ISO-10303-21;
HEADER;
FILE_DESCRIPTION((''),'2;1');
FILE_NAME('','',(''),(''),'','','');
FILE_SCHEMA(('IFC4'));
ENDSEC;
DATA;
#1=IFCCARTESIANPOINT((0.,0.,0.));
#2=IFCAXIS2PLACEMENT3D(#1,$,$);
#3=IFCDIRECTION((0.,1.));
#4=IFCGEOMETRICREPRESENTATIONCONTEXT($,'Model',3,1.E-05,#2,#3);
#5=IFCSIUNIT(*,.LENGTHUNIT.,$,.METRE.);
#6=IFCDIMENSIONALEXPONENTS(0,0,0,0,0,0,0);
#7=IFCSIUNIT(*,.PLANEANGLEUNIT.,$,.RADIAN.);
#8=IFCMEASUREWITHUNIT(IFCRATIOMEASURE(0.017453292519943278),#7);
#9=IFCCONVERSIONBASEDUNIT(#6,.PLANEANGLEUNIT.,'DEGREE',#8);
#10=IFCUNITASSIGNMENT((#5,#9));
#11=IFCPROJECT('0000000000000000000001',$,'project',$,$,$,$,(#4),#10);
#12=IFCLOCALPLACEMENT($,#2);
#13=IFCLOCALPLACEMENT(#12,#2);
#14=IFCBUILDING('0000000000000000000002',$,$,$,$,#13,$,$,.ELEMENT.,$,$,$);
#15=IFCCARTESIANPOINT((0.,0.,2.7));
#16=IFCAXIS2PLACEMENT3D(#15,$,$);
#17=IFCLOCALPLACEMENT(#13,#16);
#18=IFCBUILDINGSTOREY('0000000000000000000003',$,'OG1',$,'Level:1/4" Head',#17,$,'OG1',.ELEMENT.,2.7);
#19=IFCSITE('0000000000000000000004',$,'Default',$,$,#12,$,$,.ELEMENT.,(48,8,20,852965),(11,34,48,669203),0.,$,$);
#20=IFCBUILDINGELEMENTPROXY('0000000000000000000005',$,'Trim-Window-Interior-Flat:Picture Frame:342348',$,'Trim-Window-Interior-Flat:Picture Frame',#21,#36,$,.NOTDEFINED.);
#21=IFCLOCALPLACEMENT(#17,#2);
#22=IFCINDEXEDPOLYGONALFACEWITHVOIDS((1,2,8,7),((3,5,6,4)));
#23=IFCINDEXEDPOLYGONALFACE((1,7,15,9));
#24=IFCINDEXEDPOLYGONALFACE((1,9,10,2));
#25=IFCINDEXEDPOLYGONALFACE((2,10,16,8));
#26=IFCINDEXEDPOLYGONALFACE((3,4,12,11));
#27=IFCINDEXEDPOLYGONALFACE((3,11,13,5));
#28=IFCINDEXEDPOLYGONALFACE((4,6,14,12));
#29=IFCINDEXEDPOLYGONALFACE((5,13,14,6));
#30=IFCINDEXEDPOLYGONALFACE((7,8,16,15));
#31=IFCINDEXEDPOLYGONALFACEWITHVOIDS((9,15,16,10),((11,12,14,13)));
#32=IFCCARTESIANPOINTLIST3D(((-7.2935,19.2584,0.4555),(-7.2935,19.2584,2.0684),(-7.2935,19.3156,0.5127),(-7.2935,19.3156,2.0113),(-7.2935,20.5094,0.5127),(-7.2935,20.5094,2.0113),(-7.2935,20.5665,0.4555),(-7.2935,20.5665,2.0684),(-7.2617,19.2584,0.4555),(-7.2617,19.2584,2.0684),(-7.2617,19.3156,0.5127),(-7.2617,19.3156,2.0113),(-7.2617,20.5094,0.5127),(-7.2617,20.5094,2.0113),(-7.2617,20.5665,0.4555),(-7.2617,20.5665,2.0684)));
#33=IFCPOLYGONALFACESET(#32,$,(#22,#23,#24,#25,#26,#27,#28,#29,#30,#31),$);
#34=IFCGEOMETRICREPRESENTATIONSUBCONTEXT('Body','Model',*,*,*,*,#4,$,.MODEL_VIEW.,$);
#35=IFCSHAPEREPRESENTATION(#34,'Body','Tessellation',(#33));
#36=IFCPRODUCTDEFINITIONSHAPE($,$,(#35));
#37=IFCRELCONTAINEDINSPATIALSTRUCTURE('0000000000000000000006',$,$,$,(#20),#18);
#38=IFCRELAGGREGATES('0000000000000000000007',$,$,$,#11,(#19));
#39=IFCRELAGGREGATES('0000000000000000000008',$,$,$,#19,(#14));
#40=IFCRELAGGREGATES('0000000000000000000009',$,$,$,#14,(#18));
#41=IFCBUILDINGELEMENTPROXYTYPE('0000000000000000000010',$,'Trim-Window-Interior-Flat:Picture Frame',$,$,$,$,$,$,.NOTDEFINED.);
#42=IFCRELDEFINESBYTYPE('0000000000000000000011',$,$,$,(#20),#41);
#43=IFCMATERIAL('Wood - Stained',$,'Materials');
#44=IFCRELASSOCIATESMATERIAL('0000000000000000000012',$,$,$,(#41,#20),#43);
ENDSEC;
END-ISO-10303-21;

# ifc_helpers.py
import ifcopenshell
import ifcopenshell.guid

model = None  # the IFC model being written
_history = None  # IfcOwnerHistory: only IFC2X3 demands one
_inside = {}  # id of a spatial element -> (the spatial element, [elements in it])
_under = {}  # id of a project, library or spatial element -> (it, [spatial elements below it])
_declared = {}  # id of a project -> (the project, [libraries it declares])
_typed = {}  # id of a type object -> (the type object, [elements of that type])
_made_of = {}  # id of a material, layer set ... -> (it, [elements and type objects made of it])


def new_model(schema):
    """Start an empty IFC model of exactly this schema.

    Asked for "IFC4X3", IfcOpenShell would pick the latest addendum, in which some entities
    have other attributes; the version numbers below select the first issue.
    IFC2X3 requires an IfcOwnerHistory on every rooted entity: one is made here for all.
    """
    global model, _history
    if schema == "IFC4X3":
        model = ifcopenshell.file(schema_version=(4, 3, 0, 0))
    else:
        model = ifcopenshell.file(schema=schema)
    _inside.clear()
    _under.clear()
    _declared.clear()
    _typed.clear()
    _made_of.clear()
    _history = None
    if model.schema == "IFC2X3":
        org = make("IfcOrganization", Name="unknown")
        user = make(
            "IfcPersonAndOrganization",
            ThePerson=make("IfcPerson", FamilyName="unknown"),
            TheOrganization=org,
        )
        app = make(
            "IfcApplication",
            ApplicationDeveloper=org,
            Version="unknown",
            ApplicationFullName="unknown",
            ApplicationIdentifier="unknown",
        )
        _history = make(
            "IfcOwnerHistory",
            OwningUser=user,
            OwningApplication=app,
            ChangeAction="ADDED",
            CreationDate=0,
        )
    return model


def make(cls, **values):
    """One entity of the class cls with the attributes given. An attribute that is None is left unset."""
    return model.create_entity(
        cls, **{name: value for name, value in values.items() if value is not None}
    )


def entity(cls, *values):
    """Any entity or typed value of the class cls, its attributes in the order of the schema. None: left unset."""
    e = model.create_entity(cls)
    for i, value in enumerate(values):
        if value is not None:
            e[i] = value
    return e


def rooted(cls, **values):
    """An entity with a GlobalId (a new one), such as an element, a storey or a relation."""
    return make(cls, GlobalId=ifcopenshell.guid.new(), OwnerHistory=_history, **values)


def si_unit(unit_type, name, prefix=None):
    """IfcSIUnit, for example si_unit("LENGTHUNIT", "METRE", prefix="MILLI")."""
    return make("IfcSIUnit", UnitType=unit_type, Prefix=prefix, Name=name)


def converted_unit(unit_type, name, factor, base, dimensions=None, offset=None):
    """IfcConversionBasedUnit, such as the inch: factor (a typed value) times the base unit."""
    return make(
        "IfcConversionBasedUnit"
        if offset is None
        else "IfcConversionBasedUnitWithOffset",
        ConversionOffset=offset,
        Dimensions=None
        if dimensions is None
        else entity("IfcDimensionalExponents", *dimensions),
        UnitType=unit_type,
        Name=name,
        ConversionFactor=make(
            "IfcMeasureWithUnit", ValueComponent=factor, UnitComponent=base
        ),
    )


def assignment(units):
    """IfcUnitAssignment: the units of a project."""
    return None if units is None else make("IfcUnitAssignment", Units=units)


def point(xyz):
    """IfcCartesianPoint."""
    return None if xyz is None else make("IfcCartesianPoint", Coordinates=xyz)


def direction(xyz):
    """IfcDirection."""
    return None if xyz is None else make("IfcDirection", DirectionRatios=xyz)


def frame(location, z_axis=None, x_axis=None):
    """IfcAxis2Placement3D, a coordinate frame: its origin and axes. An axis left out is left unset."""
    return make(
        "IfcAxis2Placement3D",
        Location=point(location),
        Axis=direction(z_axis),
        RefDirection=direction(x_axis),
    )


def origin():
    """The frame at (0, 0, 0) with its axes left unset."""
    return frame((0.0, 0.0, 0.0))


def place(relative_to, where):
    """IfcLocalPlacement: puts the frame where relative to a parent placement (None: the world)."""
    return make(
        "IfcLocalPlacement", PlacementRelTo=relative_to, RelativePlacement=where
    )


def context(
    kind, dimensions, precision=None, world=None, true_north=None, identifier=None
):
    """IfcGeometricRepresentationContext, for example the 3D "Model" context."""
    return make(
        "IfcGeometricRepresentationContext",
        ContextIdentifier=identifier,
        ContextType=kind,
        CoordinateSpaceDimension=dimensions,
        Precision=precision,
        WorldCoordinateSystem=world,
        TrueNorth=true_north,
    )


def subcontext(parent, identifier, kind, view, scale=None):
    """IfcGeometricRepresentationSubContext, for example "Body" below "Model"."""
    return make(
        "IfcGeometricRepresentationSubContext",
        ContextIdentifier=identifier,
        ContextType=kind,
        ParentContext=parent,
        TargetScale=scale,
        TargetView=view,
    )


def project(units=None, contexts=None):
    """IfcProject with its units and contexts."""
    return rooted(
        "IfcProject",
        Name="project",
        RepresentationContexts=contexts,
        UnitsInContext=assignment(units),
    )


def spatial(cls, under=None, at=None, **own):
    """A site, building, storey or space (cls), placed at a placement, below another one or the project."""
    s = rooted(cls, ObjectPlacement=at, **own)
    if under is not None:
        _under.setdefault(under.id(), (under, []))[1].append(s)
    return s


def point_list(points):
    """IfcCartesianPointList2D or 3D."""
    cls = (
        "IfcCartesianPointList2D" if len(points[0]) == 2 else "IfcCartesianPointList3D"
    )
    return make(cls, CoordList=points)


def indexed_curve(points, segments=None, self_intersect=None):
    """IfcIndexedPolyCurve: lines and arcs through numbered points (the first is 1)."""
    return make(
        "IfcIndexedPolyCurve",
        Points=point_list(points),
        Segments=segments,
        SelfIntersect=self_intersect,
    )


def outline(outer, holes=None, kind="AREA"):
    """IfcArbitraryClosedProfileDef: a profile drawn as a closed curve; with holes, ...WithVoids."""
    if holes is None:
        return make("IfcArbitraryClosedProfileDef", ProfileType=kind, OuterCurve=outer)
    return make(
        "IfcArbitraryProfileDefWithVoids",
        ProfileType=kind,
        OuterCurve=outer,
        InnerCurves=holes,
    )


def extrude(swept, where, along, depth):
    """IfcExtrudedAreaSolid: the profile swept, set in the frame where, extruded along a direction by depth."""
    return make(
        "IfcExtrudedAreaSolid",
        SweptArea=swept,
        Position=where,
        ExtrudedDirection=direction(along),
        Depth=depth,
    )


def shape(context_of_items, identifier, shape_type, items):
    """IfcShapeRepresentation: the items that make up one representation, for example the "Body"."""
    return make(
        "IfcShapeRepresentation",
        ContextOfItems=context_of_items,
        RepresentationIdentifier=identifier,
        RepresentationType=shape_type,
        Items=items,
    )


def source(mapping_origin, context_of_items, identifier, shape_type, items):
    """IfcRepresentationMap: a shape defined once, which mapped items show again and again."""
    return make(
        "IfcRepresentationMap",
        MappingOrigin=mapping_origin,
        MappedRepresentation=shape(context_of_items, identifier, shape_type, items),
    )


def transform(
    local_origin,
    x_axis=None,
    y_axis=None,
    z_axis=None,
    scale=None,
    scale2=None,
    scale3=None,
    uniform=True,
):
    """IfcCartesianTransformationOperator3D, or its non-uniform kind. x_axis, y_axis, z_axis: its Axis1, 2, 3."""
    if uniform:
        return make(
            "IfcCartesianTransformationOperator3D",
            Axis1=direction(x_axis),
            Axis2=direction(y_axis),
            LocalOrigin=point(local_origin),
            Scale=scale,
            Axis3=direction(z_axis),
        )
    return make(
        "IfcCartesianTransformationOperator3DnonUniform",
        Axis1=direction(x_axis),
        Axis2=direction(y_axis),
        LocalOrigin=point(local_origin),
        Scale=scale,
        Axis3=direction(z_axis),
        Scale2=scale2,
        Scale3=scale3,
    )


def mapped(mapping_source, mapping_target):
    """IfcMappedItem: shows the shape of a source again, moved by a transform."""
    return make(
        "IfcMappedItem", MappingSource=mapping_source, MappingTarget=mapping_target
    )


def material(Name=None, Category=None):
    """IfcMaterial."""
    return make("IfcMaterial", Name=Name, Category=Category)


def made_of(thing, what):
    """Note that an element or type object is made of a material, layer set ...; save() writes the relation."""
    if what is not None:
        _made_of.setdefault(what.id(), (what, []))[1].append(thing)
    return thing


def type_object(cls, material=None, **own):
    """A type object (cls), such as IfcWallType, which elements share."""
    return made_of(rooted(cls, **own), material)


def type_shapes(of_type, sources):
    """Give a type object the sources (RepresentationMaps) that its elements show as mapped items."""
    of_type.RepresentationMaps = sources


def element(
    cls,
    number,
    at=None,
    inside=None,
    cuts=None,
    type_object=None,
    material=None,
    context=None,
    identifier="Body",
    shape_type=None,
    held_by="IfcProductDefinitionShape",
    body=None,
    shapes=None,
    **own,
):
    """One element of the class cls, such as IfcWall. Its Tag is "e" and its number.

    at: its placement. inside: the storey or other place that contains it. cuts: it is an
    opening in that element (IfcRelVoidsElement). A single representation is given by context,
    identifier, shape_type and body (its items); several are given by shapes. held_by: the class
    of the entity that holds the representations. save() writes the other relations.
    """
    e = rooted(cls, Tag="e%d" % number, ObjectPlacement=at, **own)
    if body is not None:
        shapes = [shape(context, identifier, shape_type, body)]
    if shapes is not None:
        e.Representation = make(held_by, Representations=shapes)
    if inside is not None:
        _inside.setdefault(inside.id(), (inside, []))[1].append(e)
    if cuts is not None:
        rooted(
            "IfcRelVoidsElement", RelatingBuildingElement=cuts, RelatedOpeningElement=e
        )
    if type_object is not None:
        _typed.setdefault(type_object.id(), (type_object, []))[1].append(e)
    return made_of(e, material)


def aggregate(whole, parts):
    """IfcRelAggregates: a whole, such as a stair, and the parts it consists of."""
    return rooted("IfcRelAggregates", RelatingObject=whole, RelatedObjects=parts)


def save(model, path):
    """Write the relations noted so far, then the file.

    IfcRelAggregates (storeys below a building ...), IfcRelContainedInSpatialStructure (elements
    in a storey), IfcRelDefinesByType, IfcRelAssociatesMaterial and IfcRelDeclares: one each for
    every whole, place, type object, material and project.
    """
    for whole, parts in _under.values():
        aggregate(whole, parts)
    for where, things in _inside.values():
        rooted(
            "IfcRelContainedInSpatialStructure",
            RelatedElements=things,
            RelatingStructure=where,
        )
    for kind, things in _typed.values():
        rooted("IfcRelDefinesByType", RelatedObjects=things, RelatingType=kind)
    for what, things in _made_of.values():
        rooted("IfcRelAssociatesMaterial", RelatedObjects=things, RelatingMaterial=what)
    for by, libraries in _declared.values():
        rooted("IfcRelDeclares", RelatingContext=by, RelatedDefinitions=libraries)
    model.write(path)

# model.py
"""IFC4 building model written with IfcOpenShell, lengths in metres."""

from ifc_helpers import new_model, entity, si_unit, converted_unit, direction, frame, origin, place, context, subcontext, project, spatial, indexed_curve, outline, extrude, source, transform, mapped, material, type_object, type_shapes, element, save


model = new_model("IFC4")

# Units and contexts
model_context = context("Model", 3, precision=1e-05, world=origin(), true_north=direction((0.0, 1.0)))
body_context = subcontext(model_context, "Body", "Model", "MODEL_VIEW")
ifc_project = project(units=[si_unit("LENGTHUNIT", "METRE"), converted_unit("PLANEANGLEUNIT", "DEGREE", entity("IfcRatioMeasure", 0.017453292519943278), si_unit("PLANEANGLEUNIT", "RADIAN"), dimensions=[0, 0, 0, 0, 0, 0, 0])], contexts=[model_context])

# Site, building, storey
site_placement = place(None, origin())
site = spatial("IfcSite", under=ifc_project, at=site_placement, Name="Default", CompositionType="ELEMENT", RefLatitude=(48, 8, 20, 852965), RefLongitude=(11, 34, 48, 669203), RefElevation=0.0)
building_placement = place(site_placement, origin())
building = spatial("IfcBuilding", under=site, at=building_placement, CompositionType="ELEMENT")
storey_placement = place(building_placement, frame((0.0, 0.0, 2.7)))
storey = spatial("IfcBuildingStorey", under=building, at=storey_placement, Name="OG1", ObjectType="Level:1/4\" Head", LongName="OG1", CompositionType="ELEMENT", Elevation=2.7)

# Building element proxy
ifc_material_1 = material(Name="Wood - Stained", Category="Materials")
building_element_proxy_type_1 = type_object("IfcBuildingElementProxyType", Name="Trim-Window-Interior-Flat:Picture Frame", PredefinedType="NOTDEFINED", material=ifc_material_1)
shared_shape_1 = source(origin(), body_context, "Body", "SweptSolid", [
    extrude(outline(indexed_curve([(-0.654, -0.8064), (0.654, -0.8064), (0.654, 0.8064), (-0.654, 0.8064), (-0.654, -0.8064)], self_intersect=False), holes=[indexed_curve([(-0.5969, -0.7493), (-0.5969, 0.7493), (0.5969, 0.7493), (0.5969, -0.7493), (-0.5969, -0.7493)], self_intersect=False)]), frame((0.0, -0.762, 0.0), z_axis=(0.0, 0.0, 1.0), x_axis=(-1.0, 0.0, 0.0)), (0.0, 0.0, 1.0), 0.0317),
])
type_shapes(building_element_proxy_type_1, [shared_shape_1])
for number, where, z_axis, x_axis, name in (
    (1, (-7.2617, 19.9125, 2.024), (-1.0, 0.0, 0.0), (0.0, -1.0, 0.0), "Trim-Window-Interior-Flat:Picture Frame:342348"),
):
    element("IfcBuildingElementProxy", number, at=place(storey_placement, frame(where, z_axis=z_axis, x_axis=x_axis)), inside=storey, type_object=building_element_proxy_type_1, material=ifc_material_1, Name=name, ObjectType="Trim-Window-Interior-Flat:Picture Frame", PredefinedType="NOTDEFINED", context=body_context, shape_type="MappedRepresentation", body=[
        mapped(shared_shape_1, transform((0.0, 0.0, 0.0), scale=1.0)),
    ])

save(model, "model.ifc")
